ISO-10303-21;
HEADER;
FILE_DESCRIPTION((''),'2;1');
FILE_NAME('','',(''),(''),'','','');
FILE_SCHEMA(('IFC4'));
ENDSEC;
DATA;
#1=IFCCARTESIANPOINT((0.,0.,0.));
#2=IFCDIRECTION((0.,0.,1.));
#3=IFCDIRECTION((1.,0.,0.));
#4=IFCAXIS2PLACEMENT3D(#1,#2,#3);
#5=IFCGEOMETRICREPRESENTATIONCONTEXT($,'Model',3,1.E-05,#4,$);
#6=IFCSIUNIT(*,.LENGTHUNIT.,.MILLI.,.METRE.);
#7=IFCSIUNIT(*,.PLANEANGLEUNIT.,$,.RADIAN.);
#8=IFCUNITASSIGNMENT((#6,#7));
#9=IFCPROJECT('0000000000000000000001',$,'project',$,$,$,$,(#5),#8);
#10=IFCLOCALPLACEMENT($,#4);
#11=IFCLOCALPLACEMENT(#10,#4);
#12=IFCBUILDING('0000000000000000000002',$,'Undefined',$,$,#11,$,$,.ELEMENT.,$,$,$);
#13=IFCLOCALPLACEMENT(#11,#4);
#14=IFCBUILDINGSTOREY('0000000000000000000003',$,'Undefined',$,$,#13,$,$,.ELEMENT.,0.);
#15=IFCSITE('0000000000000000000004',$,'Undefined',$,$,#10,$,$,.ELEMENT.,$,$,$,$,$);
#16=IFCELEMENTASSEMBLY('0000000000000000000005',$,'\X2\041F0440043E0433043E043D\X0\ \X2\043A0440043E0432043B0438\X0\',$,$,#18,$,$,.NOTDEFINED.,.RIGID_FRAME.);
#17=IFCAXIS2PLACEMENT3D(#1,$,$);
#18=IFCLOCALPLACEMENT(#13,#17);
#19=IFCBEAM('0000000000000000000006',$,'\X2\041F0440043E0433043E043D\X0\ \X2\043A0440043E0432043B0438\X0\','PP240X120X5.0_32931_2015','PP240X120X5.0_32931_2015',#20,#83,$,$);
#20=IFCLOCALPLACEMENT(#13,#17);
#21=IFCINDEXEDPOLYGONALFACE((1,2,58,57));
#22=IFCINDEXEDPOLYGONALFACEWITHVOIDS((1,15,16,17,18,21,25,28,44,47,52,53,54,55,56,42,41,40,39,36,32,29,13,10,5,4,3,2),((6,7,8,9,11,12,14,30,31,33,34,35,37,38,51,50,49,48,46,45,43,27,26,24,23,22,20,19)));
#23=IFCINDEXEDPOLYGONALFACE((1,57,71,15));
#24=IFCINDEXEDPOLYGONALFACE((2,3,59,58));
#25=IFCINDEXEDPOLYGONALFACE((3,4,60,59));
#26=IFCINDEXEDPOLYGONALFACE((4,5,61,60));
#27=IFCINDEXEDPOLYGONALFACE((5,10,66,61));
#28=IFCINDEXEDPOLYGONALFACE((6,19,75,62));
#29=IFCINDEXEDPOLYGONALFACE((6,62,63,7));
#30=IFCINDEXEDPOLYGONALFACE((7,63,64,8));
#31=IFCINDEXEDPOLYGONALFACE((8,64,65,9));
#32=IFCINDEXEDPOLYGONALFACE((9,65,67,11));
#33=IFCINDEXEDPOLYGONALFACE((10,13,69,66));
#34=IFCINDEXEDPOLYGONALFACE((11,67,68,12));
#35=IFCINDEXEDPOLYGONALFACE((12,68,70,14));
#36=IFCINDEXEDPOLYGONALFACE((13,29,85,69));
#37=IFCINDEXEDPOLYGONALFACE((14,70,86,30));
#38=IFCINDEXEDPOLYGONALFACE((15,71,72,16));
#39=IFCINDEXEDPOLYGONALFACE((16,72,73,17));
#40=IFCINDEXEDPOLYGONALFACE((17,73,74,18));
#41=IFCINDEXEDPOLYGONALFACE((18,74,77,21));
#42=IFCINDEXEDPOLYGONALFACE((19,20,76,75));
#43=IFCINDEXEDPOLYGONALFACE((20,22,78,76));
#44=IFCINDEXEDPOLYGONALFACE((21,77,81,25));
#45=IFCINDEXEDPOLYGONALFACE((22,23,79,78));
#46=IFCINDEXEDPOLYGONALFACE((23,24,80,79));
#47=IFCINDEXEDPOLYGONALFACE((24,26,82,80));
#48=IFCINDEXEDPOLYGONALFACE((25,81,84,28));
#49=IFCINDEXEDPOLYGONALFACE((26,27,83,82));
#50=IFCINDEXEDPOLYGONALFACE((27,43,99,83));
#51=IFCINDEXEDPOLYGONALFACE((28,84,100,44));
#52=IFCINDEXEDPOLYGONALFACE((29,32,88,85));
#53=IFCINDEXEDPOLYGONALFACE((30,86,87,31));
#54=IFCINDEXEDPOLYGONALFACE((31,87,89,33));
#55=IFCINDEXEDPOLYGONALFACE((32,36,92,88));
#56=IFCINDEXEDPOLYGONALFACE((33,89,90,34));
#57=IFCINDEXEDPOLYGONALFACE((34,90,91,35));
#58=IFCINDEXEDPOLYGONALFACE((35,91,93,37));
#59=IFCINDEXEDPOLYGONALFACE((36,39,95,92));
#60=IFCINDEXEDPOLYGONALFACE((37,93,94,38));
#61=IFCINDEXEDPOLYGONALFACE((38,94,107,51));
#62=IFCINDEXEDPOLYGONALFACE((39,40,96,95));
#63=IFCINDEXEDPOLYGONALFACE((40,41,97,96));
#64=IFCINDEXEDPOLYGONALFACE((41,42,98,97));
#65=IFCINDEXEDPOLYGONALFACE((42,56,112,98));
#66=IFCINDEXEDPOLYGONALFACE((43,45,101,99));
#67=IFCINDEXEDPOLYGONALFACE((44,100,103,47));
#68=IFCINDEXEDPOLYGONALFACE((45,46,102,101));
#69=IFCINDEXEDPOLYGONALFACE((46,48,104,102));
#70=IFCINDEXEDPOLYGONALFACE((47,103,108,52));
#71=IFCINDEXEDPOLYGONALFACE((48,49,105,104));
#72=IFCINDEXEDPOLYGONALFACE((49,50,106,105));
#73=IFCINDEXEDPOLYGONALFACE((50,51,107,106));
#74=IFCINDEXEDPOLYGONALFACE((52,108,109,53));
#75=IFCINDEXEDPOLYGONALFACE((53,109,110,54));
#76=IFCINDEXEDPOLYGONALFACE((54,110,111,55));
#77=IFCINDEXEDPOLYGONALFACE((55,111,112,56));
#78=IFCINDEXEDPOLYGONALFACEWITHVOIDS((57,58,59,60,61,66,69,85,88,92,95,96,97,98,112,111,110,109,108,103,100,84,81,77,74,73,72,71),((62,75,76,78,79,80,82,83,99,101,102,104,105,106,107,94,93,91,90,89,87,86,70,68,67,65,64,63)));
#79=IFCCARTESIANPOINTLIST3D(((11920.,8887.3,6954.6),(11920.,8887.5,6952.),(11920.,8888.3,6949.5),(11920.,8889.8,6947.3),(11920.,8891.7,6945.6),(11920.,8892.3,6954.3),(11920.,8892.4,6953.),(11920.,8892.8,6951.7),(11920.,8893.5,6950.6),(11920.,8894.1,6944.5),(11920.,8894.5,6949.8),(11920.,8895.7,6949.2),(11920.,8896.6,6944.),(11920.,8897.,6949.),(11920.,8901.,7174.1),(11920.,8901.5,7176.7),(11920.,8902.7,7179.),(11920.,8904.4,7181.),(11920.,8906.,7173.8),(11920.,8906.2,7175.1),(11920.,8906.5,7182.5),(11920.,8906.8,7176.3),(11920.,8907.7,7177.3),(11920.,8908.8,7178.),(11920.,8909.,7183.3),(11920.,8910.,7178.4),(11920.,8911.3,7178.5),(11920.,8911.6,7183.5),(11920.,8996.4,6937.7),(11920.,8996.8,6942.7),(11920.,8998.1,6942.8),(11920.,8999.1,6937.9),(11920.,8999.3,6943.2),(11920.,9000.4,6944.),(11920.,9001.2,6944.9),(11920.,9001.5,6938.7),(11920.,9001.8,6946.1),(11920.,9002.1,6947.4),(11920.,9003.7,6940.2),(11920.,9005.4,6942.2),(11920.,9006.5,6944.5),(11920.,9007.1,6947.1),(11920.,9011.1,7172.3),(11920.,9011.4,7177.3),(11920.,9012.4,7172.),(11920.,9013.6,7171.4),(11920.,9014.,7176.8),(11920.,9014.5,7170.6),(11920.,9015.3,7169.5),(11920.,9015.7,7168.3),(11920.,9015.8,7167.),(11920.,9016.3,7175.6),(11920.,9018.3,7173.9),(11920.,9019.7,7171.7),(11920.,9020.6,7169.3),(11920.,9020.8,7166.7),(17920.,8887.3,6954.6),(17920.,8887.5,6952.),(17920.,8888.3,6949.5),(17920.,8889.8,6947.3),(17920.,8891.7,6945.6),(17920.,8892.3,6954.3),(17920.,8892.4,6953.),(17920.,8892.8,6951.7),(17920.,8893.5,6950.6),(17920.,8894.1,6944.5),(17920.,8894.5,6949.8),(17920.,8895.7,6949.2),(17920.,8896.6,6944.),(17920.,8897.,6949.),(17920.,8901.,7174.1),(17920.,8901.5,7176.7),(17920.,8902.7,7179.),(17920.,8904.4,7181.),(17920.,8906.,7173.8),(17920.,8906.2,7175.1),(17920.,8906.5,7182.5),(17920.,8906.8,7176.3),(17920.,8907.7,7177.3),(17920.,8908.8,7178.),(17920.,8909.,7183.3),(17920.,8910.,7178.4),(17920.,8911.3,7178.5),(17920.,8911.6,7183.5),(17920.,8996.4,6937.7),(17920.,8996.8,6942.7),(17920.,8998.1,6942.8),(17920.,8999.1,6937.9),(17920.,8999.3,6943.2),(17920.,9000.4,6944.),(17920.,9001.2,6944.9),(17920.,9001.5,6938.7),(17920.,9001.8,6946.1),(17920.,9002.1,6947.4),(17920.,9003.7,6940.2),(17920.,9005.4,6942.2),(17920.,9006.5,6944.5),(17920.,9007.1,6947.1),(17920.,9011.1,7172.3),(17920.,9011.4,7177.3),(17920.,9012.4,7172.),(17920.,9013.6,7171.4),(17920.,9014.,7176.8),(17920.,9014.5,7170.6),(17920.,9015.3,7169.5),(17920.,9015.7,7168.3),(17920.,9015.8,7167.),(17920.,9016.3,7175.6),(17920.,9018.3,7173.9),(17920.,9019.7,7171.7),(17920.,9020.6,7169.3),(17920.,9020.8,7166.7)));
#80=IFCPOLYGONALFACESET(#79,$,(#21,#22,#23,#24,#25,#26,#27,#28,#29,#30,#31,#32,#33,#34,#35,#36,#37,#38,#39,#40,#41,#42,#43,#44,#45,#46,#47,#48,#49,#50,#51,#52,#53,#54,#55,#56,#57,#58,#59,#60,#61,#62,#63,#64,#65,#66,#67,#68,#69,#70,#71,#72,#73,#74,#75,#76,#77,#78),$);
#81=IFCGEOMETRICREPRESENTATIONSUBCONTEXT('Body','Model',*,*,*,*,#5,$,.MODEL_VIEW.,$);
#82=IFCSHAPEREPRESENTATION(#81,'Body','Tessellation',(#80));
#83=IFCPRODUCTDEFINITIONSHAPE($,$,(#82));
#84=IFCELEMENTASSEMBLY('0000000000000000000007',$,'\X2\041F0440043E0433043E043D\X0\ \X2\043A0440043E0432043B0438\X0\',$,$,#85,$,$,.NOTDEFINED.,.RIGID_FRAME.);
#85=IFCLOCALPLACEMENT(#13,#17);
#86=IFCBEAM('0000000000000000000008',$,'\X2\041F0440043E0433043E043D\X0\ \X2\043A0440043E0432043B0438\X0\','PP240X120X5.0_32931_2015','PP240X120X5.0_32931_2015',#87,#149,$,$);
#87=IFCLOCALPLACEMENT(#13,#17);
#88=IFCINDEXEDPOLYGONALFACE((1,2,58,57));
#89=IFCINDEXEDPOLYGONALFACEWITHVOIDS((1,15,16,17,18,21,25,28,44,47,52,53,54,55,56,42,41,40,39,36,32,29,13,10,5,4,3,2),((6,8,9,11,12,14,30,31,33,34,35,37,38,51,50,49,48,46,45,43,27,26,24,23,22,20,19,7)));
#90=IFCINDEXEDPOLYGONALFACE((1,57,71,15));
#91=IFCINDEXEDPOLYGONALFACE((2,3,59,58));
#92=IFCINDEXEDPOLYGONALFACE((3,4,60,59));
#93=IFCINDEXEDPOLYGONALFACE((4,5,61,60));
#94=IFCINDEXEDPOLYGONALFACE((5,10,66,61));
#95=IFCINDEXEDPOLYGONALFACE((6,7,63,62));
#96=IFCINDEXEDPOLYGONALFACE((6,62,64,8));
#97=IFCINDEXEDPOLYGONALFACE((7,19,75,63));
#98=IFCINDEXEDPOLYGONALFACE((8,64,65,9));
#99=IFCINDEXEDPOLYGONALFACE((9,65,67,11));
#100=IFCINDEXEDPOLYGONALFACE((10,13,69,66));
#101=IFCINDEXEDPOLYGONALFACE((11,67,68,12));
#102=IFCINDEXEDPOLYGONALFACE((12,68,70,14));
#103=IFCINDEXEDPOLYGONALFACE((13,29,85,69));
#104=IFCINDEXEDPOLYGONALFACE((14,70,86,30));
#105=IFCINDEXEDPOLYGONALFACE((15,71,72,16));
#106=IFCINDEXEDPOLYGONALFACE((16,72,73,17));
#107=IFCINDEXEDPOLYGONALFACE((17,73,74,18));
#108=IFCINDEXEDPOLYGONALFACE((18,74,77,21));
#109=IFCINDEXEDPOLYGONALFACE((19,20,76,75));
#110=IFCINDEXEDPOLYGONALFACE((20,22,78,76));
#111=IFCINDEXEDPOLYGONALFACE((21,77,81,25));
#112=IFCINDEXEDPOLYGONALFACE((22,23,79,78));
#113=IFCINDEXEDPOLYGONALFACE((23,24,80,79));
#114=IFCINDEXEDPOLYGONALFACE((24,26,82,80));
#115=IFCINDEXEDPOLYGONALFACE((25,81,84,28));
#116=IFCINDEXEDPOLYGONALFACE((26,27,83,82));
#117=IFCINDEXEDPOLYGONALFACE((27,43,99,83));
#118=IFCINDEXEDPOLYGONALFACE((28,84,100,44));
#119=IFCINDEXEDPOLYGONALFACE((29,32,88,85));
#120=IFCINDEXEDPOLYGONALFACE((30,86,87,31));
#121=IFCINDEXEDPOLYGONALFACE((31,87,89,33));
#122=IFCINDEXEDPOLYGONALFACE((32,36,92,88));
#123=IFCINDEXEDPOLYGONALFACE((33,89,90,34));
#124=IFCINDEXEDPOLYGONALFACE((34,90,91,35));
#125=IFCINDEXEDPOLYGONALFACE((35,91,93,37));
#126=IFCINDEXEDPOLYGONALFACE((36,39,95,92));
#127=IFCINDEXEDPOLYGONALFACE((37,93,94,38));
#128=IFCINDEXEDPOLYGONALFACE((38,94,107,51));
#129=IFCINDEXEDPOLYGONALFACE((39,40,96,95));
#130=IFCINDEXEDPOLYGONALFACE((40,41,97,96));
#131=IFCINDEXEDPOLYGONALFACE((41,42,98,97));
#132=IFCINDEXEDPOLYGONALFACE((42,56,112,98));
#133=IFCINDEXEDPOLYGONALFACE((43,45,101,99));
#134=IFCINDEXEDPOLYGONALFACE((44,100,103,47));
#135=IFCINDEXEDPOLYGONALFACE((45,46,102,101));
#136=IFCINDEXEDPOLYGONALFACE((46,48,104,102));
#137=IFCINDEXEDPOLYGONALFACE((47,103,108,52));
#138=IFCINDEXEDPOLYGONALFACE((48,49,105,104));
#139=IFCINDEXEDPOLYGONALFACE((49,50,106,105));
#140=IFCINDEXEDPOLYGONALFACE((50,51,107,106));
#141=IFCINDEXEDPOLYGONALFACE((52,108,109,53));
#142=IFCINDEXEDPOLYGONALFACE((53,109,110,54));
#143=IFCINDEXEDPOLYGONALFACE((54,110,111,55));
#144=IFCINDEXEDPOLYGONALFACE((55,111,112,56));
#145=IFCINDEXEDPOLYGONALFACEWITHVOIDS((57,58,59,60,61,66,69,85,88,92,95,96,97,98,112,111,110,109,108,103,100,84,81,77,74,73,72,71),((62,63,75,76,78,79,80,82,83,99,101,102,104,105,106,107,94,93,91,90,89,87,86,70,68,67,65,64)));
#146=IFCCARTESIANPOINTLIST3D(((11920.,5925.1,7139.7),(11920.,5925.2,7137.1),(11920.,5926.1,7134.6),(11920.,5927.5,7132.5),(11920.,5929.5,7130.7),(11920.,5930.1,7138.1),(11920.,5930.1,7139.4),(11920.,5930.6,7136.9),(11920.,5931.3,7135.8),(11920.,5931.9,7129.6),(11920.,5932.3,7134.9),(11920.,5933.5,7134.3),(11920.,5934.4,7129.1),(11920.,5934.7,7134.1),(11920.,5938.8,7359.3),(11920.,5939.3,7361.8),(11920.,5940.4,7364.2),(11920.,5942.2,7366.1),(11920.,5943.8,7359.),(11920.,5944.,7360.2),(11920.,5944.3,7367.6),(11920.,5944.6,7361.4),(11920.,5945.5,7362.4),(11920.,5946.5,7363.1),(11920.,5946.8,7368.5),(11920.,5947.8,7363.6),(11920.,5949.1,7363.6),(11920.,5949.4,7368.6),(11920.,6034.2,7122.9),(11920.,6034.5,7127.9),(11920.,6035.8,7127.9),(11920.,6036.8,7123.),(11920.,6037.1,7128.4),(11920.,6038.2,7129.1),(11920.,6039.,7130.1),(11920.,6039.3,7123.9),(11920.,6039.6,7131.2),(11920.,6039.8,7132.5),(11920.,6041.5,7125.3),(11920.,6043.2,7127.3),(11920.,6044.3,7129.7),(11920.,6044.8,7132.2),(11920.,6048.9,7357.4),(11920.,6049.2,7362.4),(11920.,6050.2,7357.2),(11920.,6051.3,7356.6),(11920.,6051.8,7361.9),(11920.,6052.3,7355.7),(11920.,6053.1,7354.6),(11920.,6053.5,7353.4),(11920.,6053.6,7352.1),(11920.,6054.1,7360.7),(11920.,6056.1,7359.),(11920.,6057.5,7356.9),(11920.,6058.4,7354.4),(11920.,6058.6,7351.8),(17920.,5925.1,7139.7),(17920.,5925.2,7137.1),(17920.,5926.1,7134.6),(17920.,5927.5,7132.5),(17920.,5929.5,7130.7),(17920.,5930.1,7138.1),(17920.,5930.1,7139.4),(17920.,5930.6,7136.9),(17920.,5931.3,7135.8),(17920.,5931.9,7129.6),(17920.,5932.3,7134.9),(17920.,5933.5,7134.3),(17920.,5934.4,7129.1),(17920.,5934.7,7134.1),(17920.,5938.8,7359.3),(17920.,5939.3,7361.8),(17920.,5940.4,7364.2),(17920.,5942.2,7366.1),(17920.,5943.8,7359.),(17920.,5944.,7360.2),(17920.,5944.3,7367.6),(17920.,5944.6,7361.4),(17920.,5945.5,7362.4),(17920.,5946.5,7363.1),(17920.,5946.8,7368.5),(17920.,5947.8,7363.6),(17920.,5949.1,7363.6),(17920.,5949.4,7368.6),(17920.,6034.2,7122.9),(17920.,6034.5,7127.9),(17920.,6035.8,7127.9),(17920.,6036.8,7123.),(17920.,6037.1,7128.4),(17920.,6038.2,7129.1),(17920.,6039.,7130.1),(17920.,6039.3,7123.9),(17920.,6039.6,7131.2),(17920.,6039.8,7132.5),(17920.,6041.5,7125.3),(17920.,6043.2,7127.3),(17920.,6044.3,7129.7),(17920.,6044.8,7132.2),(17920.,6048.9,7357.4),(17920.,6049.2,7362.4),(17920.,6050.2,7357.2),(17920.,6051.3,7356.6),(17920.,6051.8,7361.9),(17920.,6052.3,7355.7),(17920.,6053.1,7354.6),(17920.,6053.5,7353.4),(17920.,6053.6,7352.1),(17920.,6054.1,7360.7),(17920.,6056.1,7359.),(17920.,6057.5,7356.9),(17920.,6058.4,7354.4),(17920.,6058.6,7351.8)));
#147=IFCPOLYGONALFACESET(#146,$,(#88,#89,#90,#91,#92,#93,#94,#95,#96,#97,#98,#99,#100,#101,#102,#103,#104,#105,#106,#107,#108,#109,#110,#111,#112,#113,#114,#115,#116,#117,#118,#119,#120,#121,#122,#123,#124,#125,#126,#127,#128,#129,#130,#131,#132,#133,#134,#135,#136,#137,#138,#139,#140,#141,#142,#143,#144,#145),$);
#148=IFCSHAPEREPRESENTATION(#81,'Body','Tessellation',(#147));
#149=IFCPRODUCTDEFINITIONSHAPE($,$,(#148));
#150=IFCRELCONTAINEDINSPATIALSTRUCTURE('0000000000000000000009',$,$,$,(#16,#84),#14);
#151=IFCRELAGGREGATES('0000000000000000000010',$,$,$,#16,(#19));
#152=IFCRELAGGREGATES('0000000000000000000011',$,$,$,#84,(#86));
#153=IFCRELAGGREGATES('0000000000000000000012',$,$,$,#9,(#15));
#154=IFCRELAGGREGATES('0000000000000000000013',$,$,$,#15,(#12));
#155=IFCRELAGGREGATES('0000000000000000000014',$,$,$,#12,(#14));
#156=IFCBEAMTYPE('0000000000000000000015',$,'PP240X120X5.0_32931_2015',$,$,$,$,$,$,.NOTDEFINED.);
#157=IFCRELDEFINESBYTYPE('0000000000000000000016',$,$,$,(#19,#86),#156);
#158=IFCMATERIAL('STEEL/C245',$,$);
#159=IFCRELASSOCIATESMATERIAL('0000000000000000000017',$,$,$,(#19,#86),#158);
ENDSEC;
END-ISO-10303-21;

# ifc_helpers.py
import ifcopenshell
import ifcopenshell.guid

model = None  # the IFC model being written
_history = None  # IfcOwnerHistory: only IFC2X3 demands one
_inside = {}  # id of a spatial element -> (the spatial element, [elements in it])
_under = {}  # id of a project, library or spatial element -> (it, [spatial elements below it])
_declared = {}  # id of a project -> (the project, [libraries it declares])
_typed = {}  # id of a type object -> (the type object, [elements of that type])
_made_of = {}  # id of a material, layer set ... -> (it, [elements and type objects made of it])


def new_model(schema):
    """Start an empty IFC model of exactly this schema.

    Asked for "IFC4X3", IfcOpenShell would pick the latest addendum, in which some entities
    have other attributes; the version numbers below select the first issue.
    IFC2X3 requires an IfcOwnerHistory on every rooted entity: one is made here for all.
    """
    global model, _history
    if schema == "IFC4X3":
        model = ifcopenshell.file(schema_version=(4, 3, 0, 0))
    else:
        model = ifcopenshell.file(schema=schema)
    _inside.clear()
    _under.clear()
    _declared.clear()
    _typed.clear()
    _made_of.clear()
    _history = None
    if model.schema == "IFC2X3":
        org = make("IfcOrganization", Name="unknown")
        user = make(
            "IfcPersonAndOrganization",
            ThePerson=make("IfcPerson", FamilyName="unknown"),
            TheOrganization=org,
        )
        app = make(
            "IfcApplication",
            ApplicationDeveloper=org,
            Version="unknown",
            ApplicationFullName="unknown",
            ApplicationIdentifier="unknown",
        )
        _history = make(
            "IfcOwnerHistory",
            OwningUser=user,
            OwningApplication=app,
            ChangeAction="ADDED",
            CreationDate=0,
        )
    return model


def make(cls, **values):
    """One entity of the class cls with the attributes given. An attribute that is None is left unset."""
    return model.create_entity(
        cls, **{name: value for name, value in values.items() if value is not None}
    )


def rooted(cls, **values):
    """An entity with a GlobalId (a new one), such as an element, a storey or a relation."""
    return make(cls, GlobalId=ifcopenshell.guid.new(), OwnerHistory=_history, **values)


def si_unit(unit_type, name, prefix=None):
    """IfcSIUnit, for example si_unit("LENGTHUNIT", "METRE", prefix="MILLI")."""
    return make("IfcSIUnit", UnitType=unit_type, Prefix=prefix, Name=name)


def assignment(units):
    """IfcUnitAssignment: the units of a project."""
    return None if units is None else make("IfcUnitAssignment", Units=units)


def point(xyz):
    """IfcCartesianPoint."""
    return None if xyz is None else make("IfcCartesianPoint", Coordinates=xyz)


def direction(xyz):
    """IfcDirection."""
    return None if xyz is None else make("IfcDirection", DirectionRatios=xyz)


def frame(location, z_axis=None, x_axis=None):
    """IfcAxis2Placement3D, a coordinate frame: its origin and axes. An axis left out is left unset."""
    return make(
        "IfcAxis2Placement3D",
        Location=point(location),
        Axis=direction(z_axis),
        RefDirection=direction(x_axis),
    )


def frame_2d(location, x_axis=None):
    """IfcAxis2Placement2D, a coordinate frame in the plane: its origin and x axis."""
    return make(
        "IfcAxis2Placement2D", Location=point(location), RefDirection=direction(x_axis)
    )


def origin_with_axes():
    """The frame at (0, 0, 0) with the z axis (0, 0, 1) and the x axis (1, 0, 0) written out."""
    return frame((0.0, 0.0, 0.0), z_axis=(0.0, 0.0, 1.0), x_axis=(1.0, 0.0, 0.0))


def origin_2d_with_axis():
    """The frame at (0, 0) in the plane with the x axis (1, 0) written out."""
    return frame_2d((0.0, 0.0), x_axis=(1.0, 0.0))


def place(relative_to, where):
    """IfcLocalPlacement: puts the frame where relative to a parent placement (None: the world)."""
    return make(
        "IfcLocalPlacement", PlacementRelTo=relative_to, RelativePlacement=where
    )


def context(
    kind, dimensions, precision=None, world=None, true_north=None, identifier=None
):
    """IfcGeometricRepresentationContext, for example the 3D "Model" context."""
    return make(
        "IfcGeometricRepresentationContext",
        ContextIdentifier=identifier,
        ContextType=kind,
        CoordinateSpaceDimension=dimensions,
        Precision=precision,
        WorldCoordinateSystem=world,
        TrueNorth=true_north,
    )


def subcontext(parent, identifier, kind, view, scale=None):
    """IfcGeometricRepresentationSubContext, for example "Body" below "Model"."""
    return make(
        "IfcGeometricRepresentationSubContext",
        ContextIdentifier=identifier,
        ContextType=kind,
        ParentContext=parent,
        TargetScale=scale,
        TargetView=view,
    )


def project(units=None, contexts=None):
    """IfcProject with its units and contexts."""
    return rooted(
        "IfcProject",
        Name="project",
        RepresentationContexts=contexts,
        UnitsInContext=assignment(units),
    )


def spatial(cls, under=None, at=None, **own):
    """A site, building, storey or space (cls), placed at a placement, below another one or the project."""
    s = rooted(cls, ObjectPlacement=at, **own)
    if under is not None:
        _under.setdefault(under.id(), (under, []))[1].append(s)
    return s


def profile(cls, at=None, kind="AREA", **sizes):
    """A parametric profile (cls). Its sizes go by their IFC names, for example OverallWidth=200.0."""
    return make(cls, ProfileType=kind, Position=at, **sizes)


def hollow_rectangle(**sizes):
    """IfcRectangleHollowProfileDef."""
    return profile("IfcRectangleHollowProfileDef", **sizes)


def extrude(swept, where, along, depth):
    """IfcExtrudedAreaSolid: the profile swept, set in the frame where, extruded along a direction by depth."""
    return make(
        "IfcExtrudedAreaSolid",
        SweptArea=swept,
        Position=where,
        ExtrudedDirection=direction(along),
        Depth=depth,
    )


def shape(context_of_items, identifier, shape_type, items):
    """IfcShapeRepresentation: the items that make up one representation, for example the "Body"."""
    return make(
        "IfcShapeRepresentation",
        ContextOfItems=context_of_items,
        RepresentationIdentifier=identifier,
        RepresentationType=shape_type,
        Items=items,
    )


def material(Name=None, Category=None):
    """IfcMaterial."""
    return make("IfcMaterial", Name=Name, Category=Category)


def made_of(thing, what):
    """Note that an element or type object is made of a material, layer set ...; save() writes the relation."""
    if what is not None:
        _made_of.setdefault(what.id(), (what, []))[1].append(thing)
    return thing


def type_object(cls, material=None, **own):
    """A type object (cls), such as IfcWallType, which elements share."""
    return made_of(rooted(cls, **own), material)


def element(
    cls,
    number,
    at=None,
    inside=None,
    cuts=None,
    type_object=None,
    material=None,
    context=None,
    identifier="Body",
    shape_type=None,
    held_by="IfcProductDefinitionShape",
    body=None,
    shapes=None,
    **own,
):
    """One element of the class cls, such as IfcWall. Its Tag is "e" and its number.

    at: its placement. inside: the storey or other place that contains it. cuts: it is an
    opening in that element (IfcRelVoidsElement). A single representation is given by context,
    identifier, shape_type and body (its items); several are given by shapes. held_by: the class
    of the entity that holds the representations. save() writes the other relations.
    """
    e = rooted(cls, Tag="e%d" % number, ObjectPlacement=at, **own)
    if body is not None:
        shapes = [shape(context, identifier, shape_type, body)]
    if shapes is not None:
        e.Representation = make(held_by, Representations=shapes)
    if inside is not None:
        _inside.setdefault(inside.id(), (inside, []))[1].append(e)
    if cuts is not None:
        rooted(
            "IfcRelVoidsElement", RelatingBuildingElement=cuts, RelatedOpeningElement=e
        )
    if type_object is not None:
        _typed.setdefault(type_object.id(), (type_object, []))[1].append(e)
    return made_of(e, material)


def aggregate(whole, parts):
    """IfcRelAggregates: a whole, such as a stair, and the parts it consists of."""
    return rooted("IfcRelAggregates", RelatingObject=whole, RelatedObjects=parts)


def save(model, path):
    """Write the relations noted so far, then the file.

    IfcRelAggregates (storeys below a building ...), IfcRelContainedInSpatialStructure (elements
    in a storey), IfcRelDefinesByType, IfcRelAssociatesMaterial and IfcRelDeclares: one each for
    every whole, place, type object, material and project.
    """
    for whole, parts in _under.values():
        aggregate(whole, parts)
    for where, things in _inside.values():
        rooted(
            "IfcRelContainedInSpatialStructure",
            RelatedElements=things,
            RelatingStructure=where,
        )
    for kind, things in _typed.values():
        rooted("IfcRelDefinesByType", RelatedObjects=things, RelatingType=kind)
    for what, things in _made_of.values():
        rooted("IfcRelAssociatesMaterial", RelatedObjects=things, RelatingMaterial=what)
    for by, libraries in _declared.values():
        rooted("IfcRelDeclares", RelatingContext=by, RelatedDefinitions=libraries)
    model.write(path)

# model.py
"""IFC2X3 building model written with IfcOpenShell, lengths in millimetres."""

from ifc_helpers import new_model, si_unit, frame, origin_with_axes, origin_2d_with_axis, place, context, subcontext, project, spatial, hollow_rectangle, extrude, material, type_object, element, aggregate, save


model = new_model("IFC2X3")

# Units and contexts
model_context = context("Model", 3, precision=1e-05, world=origin_with_axes())
body_context = subcontext(model_context, "Body", "Model", "MODEL_VIEW")
ifc_project = project(units=[si_unit("LENGTHUNIT", "METRE", prefix="MILLI"), si_unit("PLANEANGLEUNIT", "RADIAN")], contexts=[model_context])

# Site, building, storey
site_placement = place(None, origin_with_axes())
site = spatial("IfcSite", under=ifc_project, at=site_placement, Name="Undefined", CompositionType="ELEMENT")
building_placement = place(site_placement, origin_with_axes())
building = spatial("IfcBuilding", under=site, at=building_placement, Name="Undefined", CompositionType="ELEMENT")
storey_placement = place(building_placement, origin_with_axes())
storey = spatial("IfcBuildingStorey", under=building, at=storey_placement, Name="Undefined", CompositionType="ELEMENT", Elevation=0.0)

# Shared definitions
ifc_material = material(Name="STEEL/C245")

# Element assemblies, beams
beam_type_1 = type_object("IfcBeamType", Name="PP240X120X5.0_32931_2015", PredefinedType="NOTDEFINED")
assembly_1_placement = place(storey_placement, origin_with_axes())
assembly_1 = element("IfcElementAssembly", 1, at=assembly_1_placement, inside=storey, Name="Прогон кровли", AssemblyPlace="NOTDEFINED", PredefinedType="RIGID_FRAME")
beam_1_placement = place(assembly_1_placement, frame((17920.0, 8954.0, 7060.6), z_axis=(0.0, 0.062378, 0.998053), x_axis=(-1.0, 0.0, 0.0)))
beam_1 = element("IfcBeam", 2, at=beam_1_placement, type_object=beam_type_1, material=ifc_material, Name="Прогон кровли", Description="PP240X120X5.0_32931_2015", ObjectType="PP240X120X5.0_32931_2015", context=body_context, shape_type="SweptSolid", body=[
    extrude(hollow_rectangle(XDim=120.0, YDim=240.0, WallThickness=5.0, InnerFilletRadius=5.0, OuterFilletRadius=10.0, at=origin_2d_with_axis()), frame((6000.0, 0.0, 0.0), z_axis=(-1.0, 0.0, 0.0), x_axis=(0.0, -1.0, 0.0)), (0.0, 0.0, 1.0), 6000.0),
])
aggregate(assembly_1, [beam_1])
assembly_2_placement = place(storey_placement, origin_with_axes())
assembly_2 = element("IfcElementAssembly", 3, at=assembly_2_placement, inside=storey, Name="Прогон кровли", AssemblyPlace="NOTDEFINED", PredefinedType="RIGID_FRAME")
beam_2_placement = place(assembly_2_placement, frame((17920.0, 5991.8, 7245.7), z_axis=(0.0, 0.062378, 0.998053), x_axis=(-1.0, 0.0, 0.0)))
beam_2 = element("IfcBeam", 4, at=beam_2_placement, type_object=beam_type_1, material=ifc_material, Name="Прогон кровли", Description="PP240X120X5.0_32931_2015", ObjectType="PP240X120X5.0_32931_2015", context=body_context, shape_type="SweptSolid", body=[
    extrude(hollow_rectangle(XDim=120.0, YDim=240.0, WallThickness=5.0, InnerFilletRadius=5.0, OuterFilletRadius=10.0, at=origin_2d_with_axis()), frame((6000.0, 0.0, 0.0), z_axis=(-1.0, 0.0, 0.0), x_axis=(0.0, -1.0, 0.0)), (0.0, 0.0, 1.0), 6000.0),
])
aggregate(assembly_2, [beam_2])

save(model, "model.ifc")
